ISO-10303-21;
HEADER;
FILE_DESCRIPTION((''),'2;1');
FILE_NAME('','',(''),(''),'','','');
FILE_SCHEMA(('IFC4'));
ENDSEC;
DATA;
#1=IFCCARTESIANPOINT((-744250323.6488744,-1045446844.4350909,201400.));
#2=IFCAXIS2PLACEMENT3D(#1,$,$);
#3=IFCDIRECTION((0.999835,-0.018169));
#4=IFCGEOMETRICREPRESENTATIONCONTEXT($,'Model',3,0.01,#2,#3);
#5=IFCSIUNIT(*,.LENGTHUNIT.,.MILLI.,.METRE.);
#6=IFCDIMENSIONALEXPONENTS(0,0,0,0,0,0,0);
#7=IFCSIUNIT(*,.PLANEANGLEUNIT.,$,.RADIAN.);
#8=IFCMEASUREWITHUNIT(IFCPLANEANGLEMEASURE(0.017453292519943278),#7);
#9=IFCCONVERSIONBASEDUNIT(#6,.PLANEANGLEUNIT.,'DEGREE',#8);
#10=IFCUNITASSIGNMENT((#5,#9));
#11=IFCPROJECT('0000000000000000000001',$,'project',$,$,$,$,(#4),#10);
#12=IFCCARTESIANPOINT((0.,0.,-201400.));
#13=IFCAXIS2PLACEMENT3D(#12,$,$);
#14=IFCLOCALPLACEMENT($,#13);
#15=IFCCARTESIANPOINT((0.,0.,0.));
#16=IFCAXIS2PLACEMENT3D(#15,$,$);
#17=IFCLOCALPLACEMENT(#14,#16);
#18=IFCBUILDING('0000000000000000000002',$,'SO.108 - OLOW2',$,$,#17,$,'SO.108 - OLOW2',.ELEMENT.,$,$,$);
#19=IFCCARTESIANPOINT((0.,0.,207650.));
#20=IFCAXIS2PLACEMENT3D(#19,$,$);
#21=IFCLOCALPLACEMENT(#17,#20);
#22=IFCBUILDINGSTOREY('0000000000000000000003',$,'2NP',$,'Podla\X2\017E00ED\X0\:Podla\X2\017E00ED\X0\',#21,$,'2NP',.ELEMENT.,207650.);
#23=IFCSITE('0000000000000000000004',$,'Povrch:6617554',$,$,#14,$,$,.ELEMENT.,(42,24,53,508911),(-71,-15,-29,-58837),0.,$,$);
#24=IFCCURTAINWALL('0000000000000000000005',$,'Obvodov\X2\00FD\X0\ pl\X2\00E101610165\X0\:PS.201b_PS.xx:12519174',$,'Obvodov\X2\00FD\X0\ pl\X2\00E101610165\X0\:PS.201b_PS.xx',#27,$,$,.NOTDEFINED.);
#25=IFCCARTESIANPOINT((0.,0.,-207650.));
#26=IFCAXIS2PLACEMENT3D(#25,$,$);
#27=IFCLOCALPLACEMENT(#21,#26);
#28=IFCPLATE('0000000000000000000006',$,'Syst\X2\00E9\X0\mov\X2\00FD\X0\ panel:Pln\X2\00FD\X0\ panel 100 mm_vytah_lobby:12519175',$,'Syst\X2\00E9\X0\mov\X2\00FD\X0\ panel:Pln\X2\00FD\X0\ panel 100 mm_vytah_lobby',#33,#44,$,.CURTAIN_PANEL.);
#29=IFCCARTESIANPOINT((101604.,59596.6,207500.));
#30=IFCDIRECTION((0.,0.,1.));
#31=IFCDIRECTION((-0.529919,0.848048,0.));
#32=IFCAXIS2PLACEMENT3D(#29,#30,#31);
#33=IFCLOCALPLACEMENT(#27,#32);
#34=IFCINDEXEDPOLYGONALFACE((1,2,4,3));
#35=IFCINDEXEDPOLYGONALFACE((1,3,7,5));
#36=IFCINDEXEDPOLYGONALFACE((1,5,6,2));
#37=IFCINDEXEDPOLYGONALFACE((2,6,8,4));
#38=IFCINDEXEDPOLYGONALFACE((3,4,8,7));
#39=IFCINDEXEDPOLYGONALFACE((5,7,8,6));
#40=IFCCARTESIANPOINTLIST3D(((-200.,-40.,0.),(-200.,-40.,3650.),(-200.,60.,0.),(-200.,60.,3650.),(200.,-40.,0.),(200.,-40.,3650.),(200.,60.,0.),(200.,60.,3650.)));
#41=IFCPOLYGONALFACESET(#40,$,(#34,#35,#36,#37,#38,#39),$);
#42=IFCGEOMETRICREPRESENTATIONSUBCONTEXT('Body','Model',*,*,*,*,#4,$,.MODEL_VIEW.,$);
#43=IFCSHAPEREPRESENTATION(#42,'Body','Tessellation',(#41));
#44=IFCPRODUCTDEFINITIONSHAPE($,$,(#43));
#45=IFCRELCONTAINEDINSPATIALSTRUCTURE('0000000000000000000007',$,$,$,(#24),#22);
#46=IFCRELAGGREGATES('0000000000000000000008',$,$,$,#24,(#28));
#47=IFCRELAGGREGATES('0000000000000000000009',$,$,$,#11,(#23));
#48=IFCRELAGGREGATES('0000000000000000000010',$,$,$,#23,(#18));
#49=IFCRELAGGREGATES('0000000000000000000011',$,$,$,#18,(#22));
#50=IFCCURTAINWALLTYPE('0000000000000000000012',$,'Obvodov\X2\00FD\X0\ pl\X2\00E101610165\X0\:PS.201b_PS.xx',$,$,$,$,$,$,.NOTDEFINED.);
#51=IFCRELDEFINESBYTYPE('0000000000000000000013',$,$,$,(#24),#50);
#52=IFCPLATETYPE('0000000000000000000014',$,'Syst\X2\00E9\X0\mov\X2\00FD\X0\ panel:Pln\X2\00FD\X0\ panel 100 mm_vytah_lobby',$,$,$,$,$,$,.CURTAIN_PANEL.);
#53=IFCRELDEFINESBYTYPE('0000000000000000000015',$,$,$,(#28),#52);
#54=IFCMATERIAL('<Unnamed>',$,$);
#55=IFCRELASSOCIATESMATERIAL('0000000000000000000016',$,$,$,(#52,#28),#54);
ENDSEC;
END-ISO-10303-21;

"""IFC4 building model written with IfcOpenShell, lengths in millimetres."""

from ifc_helpers import new_model, entity, si_unit, converted_unit, direction, frame, origin, place, context, subcontext, project, spatial, indexed_curve, outline, extrude, source, transform, mapped, material, type_object, type_shapes, element, aggregate, save


model = new_model("IFC4")

# Units and contexts
model_context = context("Model", 3, precision=0.01, world=frame((-744250323.6488744, -1045446844.4350909, 201400.0)), true_north=direction((0.999835, -0.018169)))
body_context = subcontext(model_context, "Body", "Model", "MODEL_VIEW")
ifc_project = project(units=[si_unit("LENGTHUNIT", "METRE", prefix="MILLI"), converted_unit("PLANEANGLEUNIT", "DEGREE", entity("IfcPlaneAngleMeasure", 0.017453292519943278), si_unit("PLANEANGLEUNIT", "RADIAN"), dimensions=[0, 0, 0, 0, 0, 0, 0])], contexts=[model_context])

# Site, building, storey
site_placement = place(None, frame((0.0, 0.0, -201400.0)))
site = spatial("IfcSite", under=ifc_project, at=site_placement, Name="Povrch:6617554", CompositionType="ELEMENT", RefLatitude=(42, 24, 53, 508911), RefLongitude=(-71, -15, -29, -58837), RefElevation=0.0)
building_placement = place(site_placement, origin())
building = spatial("IfcBuilding", under=site, at=building_placement, Name="SO.108 - OLOW2", LongName="SO.108 - OLOW2", CompositionType="ELEMENT")
storey_placement = place(building_placement, frame((0.0, 0.0, 207650.0)))
storey = spatial("IfcBuildingStorey", under=building, at=storey_placement, Name="2NP", ObjectType="Podlaží:Podlaží", LongName="2NP", CompositionType="ELEMENT", Elevation=207650.0)

# Shared definitions
ifc_material_1 = material(Name="<Unnamed>")

# Curtain wall, plate
curtain_wall_type_1 = type_object("IfcCurtainWallType", Name="Obvodový plášť:PS.201b_PS.xx", PredefinedType="NOTDEFINED")
curtain_wall_1_placement = place(storey_placement, frame((0.0, 0.0, -207650.0)))
curtain_wall_1 = element("IfcCurtainWall", 1, at=curtain_wall_1_placement, inside=storey, type_object=curtain_wall_type_1, Name="Obvodový plášť:PS.201b_PS.xx:12519174", ObjectType="Obvodový plášť:PS.201b_PS.xx", PredefinedType="NOTDEFINED")
plate_type_1 = type_object("IfcPlateType", Name="Systémový panel:Plný panel 100 mm_vytah_lobby", PredefinedType="CURTAIN_PANEL", material=ifc_material_1)
shared_shape_1 = source(origin(), body_context, "Body", "SweptSolid", [
    extrude(outline(indexed_curve([(-50.0, -200.0), (50.0, -200.0), (50.0, 200.0), (-50.0, 200.0), (-50.0, -200.0)], self_intersect=False)), frame((0.0, 10.0, 0.0), z_axis=(0.0, 0.0, 1.0), x_axis=(0.0, 1.0, 0.0)), (0.0, 0.0, 1.0), 3650.0),
])
type_shapes(plate_type_1, [shared_shape_1])
plate_1_placement = place(curtain_wall_1_placement, frame((101604.0, 59596.6, 207500.0), z_axis=(0.0, 0.0, 1.0), x_axis=(-0.529919, 0.848048, 0.0)))
plate_1 = element("IfcPlate", 2, at=plate_1_placement, type_object=plate_type_1, material=ifc_material_1, Name="Systémový panel:Plný panel 100 mm_vytah_lobby:12519175", ObjectType="Systémový panel:Plný panel 100 mm_vytah_lobby", PredefinedType="CURTAIN_PANEL", context=body_context, shape_type="MappedRepresentation", body=[
    mapped(shared_shape_1, transform((0.0, 0.0, 0.0), scale=1.0)),
])
aggregate(curtain_wall_1, [plate_1])

save(model, "model.ifc")
